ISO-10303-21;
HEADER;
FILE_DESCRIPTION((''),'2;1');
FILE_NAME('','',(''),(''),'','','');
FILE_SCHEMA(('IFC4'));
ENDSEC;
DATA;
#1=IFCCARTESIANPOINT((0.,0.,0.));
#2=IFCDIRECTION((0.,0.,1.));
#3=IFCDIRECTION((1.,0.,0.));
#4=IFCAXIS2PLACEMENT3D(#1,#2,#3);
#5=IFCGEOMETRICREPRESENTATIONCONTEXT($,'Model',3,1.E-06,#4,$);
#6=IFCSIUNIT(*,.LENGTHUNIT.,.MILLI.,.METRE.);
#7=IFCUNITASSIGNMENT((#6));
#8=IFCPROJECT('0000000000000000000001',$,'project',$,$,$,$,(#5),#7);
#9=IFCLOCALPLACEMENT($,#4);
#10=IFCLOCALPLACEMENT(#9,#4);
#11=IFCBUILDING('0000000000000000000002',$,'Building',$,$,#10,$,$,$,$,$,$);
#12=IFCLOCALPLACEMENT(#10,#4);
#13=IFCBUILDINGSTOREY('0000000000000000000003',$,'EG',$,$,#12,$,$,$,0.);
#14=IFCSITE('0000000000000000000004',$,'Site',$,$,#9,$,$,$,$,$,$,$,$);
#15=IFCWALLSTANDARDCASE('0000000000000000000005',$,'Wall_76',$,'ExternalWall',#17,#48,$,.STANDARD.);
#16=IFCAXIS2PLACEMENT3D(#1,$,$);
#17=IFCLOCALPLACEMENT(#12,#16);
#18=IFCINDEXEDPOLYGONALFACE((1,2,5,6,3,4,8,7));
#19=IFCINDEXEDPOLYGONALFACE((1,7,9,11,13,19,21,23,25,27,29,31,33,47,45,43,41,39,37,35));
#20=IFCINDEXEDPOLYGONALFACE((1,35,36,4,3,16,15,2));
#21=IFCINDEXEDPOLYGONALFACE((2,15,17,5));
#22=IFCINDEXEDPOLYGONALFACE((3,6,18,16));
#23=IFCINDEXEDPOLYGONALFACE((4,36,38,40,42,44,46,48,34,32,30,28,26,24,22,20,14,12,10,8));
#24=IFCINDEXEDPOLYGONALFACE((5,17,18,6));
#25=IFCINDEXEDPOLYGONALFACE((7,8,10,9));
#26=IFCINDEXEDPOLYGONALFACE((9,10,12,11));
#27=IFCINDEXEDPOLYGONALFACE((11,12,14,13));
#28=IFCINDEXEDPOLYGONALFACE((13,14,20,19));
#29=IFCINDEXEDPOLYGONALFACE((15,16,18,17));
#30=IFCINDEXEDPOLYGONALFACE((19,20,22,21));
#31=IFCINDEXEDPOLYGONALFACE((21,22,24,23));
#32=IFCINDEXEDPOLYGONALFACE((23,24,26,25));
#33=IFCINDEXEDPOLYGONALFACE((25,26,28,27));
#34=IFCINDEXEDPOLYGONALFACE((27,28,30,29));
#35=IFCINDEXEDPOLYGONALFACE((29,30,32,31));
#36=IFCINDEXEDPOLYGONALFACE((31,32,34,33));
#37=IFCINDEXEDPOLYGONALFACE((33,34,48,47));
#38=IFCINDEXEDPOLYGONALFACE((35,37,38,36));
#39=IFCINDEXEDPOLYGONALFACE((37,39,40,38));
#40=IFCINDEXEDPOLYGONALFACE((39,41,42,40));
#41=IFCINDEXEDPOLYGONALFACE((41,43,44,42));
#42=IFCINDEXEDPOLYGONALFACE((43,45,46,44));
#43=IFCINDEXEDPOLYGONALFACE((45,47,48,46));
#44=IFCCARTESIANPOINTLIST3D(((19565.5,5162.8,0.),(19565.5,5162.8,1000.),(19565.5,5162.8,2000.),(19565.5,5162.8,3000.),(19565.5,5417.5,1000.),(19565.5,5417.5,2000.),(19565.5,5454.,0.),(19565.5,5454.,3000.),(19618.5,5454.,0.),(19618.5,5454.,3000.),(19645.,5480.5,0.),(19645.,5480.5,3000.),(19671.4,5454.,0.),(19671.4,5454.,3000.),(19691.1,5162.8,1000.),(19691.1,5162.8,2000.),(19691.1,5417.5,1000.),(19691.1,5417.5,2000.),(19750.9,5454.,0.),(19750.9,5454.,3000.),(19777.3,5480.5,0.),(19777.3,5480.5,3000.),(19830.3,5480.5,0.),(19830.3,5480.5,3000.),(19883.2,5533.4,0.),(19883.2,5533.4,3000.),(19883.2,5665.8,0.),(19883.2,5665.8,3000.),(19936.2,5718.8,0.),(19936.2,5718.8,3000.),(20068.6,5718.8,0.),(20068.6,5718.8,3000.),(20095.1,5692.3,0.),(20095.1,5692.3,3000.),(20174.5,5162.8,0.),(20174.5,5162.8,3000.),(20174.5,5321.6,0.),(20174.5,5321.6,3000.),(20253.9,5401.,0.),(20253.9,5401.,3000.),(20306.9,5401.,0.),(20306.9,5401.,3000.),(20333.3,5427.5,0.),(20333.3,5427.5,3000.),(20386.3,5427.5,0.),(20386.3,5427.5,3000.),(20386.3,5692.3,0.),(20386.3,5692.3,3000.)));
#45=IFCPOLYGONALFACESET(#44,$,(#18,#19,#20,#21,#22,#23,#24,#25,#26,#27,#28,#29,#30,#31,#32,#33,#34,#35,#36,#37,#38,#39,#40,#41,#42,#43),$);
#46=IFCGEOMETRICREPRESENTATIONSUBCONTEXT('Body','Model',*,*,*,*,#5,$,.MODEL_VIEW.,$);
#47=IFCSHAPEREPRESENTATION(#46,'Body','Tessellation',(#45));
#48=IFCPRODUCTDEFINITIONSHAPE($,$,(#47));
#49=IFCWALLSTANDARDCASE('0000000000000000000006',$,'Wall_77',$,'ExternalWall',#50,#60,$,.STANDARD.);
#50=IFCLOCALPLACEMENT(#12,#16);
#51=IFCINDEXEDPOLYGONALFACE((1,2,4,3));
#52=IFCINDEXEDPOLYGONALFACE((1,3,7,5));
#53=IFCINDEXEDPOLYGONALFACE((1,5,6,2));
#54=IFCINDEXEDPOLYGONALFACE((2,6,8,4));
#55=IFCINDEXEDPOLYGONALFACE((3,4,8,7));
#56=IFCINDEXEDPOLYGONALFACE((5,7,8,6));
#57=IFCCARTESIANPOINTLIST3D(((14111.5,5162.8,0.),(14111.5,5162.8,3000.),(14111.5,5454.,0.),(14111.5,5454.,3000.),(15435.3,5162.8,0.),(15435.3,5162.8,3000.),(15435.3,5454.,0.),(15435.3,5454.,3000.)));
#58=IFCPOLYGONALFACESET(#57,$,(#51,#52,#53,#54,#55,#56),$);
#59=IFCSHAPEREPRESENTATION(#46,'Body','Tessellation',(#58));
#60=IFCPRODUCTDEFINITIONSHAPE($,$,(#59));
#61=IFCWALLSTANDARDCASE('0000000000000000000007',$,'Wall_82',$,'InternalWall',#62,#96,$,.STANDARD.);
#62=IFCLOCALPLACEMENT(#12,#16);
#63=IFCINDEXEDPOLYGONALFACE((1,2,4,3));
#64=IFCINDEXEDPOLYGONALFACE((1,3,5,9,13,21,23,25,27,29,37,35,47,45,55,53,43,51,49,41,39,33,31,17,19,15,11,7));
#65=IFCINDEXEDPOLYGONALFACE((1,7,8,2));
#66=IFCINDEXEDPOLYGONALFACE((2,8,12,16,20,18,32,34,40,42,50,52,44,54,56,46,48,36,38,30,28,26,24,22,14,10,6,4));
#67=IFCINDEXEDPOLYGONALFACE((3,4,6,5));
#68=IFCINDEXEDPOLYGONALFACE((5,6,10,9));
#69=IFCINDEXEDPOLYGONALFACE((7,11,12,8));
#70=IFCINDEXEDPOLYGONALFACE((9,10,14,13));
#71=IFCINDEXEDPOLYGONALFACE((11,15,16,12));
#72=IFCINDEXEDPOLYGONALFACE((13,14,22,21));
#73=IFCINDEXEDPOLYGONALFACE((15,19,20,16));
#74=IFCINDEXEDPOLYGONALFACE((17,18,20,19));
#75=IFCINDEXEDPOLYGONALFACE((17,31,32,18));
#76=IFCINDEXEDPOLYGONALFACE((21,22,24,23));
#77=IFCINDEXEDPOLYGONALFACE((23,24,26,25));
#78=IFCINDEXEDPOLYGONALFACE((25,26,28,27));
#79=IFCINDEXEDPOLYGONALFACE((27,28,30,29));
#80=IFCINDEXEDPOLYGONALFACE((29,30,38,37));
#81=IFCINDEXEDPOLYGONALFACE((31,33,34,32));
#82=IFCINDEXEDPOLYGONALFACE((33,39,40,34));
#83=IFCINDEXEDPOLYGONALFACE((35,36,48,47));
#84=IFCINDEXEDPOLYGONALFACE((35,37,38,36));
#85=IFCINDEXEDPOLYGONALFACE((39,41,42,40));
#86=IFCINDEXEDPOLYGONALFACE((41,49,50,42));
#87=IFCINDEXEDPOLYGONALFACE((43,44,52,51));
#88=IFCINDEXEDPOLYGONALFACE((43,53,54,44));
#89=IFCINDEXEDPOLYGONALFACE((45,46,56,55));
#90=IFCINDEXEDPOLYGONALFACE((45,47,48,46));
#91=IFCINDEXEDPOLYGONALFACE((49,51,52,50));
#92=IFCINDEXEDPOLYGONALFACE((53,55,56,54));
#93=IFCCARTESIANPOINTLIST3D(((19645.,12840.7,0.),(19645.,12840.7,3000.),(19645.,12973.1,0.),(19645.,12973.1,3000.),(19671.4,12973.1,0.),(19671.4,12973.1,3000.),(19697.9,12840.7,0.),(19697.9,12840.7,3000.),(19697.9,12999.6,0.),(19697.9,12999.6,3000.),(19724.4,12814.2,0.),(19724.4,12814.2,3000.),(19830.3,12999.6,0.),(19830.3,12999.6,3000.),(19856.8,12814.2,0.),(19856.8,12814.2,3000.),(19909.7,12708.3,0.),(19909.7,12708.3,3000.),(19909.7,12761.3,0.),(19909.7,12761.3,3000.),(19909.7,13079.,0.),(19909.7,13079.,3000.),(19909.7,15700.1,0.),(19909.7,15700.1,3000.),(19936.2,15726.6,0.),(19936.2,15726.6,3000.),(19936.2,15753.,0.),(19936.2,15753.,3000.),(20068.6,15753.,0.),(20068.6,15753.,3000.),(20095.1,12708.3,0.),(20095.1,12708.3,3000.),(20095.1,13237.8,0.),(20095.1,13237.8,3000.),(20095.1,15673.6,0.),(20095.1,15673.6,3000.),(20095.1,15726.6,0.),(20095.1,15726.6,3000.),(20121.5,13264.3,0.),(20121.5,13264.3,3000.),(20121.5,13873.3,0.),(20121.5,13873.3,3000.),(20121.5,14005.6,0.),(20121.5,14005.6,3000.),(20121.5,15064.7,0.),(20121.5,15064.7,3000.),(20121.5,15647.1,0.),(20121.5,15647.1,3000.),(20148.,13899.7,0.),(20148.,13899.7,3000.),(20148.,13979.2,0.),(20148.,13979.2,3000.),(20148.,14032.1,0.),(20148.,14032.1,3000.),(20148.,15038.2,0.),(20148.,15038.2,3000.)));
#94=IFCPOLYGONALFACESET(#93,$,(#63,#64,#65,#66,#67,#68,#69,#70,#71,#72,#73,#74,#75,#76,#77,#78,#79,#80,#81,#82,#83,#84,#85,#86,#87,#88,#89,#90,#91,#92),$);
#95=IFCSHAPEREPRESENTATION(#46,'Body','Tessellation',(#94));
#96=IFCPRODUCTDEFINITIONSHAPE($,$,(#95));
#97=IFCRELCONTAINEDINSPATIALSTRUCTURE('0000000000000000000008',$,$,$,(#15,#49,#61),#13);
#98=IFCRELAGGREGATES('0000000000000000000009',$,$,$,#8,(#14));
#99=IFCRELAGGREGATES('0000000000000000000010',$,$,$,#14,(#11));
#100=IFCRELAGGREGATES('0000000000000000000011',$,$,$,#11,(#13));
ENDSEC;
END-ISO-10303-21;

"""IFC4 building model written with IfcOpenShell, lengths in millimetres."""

from ifc_helpers import new_model, si_unit, frame, origin_with_axes, place, context, subcontext, project, spatial, polyline, rectangle, outline, extrude, element, save


model = new_model("IFC4")

# Units and contexts
model_context = context("Model", 3, precision=1e-06, world=origin_with_axes())
body_context = subcontext(model_context, "Body", "Model", "MODEL_VIEW")
ifc_project = project(units=[si_unit("LENGTHUNIT", "METRE", prefix="MILLI")], contexts=[model_context])

# Site, building, storey
site_placement = place(None, origin_with_axes())
site = spatial("IfcSite", under=ifc_project, at=site_placement, Name="Site")
building_placement = place(site_placement, origin_with_axes())
building = spatial("IfcBuilding", under=site, at=building_placement, Name="Building")
storey_placement = place(building_placement, origin_with_axes())
storey = spatial("IfcBuildingStorey", under=building, at=storey_placement, Name="EG", Elevation=0.0)

# Wall, opening
wall_1_placement = place(storey_placement, origin_with_axes())
wall_1 = element("IfcWallStandardCase", 1, at=wall_1_placement, inside=storey, Name="Wall_76", ObjectType="ExternalWall", PredefinedType="STANDARD", context=body_context, shape_type="SweptSolid", body=[
    extrude(outline(polyline([(19565.5, 5162.8, 0.0), (19565.5, 5454.0, 0.0), (19618.5, 5454.0, 0.0), (19645.0, 5480.5, 0.0), (19671.4, 5454.0, 0.0), (19750.9, 5454.0, 0.0), (19777.3, 5480.5, 0.0), (19830.3, 5480.5, 0.0), (19883.2, 5533.4, 0.0), (19883.2, 5665.8, 0.0), (19936.2, 5718.8, 0.0), (20068.6, 5718.8, 0.0), (20095.1, 5692.3, 0.0), (20386.3, 5692.3, 0.0), (20386.3, 5427.5, 0.0), (20333.3, 5427.5, 0.0), (20306.9, 5401.0, 0.0), (20253.9, 5401.0, 0.0), (20174.5, 5321.6, 0.0), (20174.5, 5162.8, 0.0), (19565.5, 5162.8, 0.0)])), origin_with_axes(), (0.0, 0.0, 1.0), 3000.0),
])
opening_1_placement = place(wall_1_placement, origin_with_axes())
element("IfcOpeningElement", 2, at=opening_1_placement, inside=storey, cuts=wall_1, context=body_context, shape_type="SweptSolid", body=[
    extrude(rectangle(XDim=264.8, YDim=240.0), frame((19571.1, 5285.1, 1000.0), z_axis=(0.0, 0.0, 1.0), x_axis=(0.0, 1.0, 0.0)), (0.0, 0.0, 1.0), 1000.0),
])

# Walls
for number, where, z_axis, x_axis, name in (
    (3, (0.0, 0.0, 0.0), (0.0, 0.0, 1.0), (1.0, 0.0, 0.0), "Wall_77"),
):
    element("IfcWallStandardCase", number, at=place(storey_placement, frame(where, z_axis=z_axis, x_axis=x_axis)), inside=storey, Name=name, ObjectType="ExternalWall", PredefinedType="STANDARD", context=body_context, shape_type="SweptSolid", body=[
        extrude(outline(polyline([(14111.5, 5162.8, 0.0), (14111.5, 5454.0, 0.0), (15435.3, 5454.0, 0.0), (15435.3, 5162.8, 0.0), (14111.5, 5162.8, 0.0)])), origin_with_axes(), (0.0, 0.0, 1.0), 3000.0),
    ])
for number, where, z_axis, x_axis, name in (
    (4, (0.0, 0.0, 0.0), (0.0, 0.0, 1.0), (1.0, 0.0, 0.0), "Wall_82"),
):
    element("IfcWallStandardCase", number, at=place(storey_placement, frame(where, z_axis=z_axis, x_axis=x_axis)), inside=storey, Name=name, ObjectType="InternalWall", PredefinedType="STANDARD", context=body_context, shape_type="SweptSolid", body=[
        extrude(outline(polyline([(19909.7, 12708.3, 0.0), (19909.7, 12761.3, 0.0), (19856.8, 12814.2, 0.0), (19724.4, 12814.2, 0.0), (19697.9, 12840.7, 0.0), (19645.0, 12840.7, 0.0), (19645.0, 12973.1, 0.0), (19671.4, 12973.1, 0.0), (19697.9, 12999.6, 0.0), (19830.3, 12999.6, 0.0), (19909.7, 13079.0, 0.0), (19909.7, 15700.1, 0.0), (19936.2, 15726.6, 0.0), (19936.2, 15753.0, 0.0), (20068.6, 15753.0, 0.0), (20095.1, 15726.6, 0.0), (20095.1, 15673.6, 0.0), (20121.5, 15647.1, 0.0), (20121.5, 15064.7, 0.0), (20148.0, 15038.2, 0.0), (20148.0, 14032.1, 0.0), (20121.5, 14005.6, 0.0), (20148.0, 13979.2, 0.0), (20148.0, 13899.7, 0.0), (20121.5, 13873.3, 0.0), (20121.5, 13264.3, 0.0), (20095.1, 13237.8, 0.0), (20095.1, 12708.3, 0.0), (19909.7, 12708.3, 0.0)])), origin_with_axes(), (0.0, 0.0, 1.0), 3000.0),
    ])

save(model, "model.ifc")
